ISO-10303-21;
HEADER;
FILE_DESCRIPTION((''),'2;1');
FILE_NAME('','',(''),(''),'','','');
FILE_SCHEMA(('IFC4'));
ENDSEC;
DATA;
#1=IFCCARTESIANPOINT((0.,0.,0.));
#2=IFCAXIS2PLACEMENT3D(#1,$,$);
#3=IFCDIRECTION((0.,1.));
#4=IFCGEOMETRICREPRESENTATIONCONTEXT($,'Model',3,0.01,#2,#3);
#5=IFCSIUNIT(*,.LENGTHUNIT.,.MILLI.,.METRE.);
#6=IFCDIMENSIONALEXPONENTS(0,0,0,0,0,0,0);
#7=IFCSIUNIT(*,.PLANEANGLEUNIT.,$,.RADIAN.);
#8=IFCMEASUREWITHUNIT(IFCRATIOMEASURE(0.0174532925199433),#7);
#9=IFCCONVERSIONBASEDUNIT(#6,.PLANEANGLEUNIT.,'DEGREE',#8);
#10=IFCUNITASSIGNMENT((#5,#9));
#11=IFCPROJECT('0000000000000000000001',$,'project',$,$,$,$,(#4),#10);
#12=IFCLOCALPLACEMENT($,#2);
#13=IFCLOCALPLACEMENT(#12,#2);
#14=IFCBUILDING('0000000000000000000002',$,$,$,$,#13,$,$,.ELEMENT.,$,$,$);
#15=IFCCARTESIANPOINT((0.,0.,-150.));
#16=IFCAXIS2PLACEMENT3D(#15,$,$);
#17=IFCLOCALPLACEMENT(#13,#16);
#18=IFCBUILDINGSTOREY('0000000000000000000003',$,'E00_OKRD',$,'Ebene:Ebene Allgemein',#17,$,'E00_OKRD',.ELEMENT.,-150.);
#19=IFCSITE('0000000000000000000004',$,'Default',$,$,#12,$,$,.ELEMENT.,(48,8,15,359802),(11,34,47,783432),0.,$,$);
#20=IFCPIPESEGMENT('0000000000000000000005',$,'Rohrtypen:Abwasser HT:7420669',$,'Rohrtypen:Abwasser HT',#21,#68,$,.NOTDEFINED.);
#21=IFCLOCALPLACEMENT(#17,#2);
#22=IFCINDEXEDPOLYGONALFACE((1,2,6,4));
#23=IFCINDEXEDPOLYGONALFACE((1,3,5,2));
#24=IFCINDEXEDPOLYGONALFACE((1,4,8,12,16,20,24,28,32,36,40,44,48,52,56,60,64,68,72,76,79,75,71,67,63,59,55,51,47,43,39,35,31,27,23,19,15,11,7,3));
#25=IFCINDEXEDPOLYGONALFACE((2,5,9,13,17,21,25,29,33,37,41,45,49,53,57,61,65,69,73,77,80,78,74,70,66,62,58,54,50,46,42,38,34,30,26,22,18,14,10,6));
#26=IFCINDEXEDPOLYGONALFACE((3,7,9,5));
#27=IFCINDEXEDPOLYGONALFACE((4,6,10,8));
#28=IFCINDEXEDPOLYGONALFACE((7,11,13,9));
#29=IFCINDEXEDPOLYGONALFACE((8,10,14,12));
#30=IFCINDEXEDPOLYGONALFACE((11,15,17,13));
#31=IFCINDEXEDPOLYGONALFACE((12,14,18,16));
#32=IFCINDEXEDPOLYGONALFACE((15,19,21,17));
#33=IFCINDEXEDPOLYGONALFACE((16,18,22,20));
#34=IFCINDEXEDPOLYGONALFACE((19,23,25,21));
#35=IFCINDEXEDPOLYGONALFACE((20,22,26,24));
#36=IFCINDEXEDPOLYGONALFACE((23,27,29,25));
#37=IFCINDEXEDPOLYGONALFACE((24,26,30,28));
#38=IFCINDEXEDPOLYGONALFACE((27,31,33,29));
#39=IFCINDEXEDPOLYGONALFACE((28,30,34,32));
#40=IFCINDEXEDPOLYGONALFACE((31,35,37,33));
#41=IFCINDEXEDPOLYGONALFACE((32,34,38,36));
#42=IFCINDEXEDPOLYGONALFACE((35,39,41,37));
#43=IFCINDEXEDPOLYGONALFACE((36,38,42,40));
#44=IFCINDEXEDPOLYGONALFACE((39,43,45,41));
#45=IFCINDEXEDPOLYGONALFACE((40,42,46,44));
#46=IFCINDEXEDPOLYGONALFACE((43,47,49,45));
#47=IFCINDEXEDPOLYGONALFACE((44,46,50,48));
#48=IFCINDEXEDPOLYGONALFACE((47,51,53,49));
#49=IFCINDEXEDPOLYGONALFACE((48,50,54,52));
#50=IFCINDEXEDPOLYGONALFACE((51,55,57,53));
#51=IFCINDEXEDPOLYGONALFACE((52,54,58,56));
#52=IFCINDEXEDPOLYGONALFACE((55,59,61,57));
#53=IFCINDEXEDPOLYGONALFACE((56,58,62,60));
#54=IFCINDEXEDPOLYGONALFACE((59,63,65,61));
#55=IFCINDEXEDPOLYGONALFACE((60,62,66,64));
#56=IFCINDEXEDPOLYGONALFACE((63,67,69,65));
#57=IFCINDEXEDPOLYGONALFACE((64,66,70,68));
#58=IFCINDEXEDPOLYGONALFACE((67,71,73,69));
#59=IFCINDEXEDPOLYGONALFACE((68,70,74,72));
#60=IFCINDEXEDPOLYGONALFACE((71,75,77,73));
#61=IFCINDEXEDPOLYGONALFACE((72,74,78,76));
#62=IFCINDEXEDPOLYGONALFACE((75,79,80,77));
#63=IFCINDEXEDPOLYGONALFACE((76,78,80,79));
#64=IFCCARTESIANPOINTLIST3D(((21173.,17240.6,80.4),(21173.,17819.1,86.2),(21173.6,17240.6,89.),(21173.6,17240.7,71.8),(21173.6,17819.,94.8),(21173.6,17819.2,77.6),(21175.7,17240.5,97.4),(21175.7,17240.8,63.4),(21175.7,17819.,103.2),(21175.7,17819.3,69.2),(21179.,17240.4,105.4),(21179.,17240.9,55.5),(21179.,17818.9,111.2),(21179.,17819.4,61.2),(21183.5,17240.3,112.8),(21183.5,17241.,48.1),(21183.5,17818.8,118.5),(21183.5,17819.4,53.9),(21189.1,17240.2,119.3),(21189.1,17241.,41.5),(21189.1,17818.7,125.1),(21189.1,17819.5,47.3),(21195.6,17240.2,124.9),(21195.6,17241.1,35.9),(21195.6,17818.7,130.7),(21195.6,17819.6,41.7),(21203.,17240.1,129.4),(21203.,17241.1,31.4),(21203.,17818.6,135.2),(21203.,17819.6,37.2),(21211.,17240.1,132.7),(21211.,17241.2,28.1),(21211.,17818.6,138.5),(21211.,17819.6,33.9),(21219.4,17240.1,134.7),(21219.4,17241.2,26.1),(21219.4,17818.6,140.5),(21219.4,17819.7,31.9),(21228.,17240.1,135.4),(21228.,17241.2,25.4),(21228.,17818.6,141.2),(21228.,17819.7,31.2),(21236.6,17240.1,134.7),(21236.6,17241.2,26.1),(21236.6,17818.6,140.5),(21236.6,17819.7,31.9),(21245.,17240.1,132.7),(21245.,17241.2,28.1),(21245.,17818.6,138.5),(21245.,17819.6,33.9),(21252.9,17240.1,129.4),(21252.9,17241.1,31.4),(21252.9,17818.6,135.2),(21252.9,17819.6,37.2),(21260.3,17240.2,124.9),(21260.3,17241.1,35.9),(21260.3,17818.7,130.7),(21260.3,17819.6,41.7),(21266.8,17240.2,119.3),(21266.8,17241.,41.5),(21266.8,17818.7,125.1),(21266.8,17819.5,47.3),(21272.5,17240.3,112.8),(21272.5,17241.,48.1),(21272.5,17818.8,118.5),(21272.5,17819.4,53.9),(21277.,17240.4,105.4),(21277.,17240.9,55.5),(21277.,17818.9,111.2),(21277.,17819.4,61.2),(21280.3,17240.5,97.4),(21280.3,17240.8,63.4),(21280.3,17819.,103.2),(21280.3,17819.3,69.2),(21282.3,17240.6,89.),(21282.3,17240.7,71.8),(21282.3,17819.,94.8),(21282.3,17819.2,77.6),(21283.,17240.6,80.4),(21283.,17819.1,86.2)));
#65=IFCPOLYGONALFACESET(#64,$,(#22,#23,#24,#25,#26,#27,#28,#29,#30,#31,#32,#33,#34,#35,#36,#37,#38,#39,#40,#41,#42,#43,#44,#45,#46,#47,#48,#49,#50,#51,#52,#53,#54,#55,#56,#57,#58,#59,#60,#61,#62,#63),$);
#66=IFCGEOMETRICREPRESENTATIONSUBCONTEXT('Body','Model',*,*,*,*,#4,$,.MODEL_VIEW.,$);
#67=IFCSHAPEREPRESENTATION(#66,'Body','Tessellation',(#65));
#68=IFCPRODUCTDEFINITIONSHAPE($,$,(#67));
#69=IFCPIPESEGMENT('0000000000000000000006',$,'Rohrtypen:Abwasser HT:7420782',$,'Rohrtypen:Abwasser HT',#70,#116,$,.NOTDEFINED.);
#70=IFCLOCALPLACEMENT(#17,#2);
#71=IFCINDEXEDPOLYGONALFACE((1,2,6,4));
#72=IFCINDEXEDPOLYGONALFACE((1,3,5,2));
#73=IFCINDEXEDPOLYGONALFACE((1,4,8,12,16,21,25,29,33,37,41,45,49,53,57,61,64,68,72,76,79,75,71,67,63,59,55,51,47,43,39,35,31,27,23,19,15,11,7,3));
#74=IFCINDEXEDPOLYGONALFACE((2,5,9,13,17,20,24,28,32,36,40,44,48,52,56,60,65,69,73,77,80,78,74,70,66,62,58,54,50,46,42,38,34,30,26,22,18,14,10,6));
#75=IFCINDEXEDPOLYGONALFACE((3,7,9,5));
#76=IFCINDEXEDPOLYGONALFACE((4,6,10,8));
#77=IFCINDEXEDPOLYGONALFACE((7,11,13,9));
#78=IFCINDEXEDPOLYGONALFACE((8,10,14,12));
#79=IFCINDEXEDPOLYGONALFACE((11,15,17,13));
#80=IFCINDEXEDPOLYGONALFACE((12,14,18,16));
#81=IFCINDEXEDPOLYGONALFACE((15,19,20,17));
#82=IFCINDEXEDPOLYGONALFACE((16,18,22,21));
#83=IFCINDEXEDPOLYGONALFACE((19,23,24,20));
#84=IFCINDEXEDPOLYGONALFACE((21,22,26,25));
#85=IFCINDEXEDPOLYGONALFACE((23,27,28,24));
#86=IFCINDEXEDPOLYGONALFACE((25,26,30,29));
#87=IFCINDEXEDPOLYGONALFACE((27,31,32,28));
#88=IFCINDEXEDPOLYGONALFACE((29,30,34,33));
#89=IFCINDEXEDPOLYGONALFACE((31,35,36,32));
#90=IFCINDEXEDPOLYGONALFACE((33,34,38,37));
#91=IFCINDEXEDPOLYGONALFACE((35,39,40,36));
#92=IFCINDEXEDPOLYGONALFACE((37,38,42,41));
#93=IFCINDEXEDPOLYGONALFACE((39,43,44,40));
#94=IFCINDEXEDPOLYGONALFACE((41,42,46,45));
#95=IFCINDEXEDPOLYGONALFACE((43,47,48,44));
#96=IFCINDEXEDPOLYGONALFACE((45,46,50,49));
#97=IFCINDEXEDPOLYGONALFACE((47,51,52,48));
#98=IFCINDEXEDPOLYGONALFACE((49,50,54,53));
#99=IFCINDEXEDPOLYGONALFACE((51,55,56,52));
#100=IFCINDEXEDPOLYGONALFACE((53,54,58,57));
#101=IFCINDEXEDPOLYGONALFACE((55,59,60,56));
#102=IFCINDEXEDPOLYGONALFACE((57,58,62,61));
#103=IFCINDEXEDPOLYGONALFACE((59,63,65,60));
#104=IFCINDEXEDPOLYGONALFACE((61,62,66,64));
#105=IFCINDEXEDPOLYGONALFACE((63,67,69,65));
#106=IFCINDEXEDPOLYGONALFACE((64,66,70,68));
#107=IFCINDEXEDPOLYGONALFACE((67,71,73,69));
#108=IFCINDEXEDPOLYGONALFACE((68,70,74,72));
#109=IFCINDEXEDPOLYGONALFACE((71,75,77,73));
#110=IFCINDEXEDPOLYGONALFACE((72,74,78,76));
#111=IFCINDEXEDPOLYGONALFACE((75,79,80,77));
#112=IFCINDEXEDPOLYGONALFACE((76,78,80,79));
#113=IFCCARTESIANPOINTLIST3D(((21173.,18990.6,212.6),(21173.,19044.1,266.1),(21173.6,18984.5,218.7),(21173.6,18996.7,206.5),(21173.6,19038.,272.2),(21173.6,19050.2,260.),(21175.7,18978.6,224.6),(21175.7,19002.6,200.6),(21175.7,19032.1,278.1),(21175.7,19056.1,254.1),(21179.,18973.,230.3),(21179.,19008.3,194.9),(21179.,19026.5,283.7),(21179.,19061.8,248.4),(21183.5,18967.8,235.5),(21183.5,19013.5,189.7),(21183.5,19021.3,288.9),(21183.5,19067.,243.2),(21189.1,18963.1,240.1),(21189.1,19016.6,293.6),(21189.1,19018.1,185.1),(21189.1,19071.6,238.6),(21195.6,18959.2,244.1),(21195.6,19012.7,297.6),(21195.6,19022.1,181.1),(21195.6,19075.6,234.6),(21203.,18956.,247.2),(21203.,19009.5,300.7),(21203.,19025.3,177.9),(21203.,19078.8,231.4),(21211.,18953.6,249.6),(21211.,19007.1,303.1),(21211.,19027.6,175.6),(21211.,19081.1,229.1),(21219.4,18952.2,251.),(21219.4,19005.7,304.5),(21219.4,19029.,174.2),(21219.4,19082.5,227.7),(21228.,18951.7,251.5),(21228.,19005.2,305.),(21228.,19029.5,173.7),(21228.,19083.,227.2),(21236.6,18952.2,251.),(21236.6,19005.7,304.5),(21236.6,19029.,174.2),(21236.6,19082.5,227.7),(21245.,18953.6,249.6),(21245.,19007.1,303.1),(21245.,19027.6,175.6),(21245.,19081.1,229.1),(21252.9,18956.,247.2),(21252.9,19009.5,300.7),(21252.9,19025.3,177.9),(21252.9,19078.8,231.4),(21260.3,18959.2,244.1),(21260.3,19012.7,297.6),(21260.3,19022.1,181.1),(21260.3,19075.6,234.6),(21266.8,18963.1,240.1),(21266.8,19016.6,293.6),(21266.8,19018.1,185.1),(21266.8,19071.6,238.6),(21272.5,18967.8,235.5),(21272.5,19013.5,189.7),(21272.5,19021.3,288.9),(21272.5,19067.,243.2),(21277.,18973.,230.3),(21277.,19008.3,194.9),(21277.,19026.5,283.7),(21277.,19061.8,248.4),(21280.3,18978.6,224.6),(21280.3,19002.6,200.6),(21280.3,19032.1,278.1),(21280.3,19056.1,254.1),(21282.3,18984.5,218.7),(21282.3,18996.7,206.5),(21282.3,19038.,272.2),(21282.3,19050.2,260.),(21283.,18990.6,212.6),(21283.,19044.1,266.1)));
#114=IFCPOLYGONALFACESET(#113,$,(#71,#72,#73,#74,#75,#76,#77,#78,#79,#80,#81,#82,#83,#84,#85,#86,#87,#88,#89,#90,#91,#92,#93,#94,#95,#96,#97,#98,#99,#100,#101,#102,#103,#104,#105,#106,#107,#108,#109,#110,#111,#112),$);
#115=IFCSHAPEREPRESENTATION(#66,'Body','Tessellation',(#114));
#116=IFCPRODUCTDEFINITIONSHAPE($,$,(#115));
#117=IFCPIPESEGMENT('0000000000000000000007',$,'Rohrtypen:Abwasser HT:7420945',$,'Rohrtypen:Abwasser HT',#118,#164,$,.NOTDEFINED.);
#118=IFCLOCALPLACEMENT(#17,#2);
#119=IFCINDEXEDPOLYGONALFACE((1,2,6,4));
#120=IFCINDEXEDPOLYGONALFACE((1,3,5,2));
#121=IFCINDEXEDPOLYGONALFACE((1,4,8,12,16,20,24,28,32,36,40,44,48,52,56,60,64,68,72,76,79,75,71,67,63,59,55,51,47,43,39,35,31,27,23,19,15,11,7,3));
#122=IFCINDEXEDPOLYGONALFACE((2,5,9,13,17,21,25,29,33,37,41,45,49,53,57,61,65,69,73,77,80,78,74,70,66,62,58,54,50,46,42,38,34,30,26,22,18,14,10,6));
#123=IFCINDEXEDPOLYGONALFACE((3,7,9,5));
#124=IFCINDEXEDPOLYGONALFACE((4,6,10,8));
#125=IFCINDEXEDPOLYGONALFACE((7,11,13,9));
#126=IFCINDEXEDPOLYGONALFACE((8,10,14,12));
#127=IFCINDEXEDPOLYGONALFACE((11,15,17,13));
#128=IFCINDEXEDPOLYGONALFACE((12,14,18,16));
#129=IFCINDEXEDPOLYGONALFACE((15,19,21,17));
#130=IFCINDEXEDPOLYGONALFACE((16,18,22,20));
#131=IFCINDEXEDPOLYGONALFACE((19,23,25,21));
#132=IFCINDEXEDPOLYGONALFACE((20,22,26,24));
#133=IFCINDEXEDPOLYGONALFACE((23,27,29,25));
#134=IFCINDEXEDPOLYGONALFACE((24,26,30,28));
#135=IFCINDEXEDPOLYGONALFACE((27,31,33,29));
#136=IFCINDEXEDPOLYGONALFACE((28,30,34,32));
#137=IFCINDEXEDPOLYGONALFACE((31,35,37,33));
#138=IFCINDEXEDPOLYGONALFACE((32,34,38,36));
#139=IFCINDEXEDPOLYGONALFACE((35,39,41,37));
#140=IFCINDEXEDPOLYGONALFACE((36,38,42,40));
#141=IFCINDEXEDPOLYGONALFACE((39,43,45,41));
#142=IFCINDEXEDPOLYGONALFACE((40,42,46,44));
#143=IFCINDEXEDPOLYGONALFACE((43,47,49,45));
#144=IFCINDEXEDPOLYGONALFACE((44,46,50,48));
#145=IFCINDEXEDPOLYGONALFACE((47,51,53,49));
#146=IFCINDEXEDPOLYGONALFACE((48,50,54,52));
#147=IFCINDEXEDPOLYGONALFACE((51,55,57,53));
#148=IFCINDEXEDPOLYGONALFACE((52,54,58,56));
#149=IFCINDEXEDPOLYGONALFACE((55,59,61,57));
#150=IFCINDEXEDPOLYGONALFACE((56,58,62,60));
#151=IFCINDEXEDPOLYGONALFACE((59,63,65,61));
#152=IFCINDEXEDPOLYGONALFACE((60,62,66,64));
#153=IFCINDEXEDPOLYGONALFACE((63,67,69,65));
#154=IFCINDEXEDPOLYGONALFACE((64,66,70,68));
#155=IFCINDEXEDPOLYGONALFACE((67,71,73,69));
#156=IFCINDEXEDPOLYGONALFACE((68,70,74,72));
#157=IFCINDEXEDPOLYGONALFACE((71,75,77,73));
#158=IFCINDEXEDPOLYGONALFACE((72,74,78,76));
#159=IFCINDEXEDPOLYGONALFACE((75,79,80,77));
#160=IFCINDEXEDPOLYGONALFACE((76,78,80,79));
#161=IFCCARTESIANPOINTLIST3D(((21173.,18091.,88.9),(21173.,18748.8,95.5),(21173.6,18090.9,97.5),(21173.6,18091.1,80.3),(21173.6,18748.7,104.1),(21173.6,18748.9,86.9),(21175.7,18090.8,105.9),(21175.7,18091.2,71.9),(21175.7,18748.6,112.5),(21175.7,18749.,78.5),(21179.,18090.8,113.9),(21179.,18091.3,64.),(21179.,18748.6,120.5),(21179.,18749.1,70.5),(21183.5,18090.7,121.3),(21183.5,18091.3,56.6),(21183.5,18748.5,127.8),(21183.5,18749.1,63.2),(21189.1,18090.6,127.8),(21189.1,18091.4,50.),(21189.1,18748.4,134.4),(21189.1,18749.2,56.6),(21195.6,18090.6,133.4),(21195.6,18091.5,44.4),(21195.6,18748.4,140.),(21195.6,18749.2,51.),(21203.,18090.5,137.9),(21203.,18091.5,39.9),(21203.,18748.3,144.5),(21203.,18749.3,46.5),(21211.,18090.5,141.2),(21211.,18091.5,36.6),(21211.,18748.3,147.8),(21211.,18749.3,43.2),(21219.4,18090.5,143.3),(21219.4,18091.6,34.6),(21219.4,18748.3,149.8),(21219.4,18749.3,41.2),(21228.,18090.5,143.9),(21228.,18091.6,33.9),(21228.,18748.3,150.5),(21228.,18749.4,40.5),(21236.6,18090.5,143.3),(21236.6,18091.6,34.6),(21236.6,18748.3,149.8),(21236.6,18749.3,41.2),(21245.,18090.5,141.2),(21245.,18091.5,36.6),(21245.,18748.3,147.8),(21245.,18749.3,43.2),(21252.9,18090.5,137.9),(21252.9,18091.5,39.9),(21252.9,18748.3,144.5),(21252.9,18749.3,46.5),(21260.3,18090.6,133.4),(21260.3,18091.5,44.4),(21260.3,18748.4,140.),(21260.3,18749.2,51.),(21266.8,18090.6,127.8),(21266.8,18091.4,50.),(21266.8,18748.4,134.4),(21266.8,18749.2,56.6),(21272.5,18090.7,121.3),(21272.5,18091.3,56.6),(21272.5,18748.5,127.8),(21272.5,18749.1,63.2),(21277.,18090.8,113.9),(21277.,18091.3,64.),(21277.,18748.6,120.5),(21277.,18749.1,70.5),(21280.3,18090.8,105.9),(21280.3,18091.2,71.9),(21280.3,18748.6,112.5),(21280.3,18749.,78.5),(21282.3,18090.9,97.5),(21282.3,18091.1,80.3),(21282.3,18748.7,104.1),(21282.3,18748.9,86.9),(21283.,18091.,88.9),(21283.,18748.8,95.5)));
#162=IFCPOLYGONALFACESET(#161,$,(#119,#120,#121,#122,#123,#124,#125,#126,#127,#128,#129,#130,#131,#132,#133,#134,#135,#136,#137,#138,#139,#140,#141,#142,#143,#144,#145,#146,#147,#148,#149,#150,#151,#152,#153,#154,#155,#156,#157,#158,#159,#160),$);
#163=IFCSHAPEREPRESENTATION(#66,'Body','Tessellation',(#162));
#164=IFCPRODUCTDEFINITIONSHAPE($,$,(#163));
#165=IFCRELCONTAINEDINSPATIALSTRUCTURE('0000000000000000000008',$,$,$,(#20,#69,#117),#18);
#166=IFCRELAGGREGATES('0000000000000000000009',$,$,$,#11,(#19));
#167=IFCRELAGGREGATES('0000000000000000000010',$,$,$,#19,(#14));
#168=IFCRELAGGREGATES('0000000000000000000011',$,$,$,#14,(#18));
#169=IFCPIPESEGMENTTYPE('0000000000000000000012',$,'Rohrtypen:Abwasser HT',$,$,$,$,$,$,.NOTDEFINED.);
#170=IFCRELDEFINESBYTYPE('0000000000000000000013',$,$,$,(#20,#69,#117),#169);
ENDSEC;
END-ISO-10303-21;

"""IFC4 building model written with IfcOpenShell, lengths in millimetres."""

from ifc_helpers import new_model, entity, si_unit, converted_unit, direction, frame, origin, place, context, subcontext, project, spatial, indexed_curve, outline, extrude, type_object, element, save


model = new_model("IFC4")

# Units and contexts
model_context = context("Model", 3, precision=0.01, world=origin(), true_north=direction((0.0, 1.0)))
body_context = subcontext(model_context, "Body", "Model", "MODEL_VIEW")
ifc_project = project(units=[si_unit("LENGTHUNIT", "METRE", prefix="MILLI"), converted_unit("PLANEANGLEUNIT", "DEGREE", entity("IfcRatioMeasure", 0.0174532925199433), si_unit("PLANEANGLEUNIT", "RADIAN"), dimensions=[0, 0, 0, 0, 0, 0, 0])], contexts=[model_context])

# Site, building, storey
site_placement = place(None, origin())
site = spatial("IfcSite", under=ifc_project, at=site_placement, Name="Default", CompositionType="ELEMENT", RefLatitude=(48, 8, 15, 359802), RefLongitude=(11, 34, 47, 783432), RefElevation=0.0)
building_placement = place(site_placement, origin())
building = spatial("IfcBuilding", under=site, at=building_placement, CompositionType="ELEMENT")
storey_placement = place(building_placement, frame((0.0, 0.0, -150.0)))
storey = spatial("IfcBuildingStorey", under=building, at=storey_placement, Name="E00_OKRD", ObjectType="Ebene:Ebene Allgemein", LongName="E00_OKRD", CompositionType="ELEMENT", Elevation=-150.0)

# Pipe segments
pipe_segment_type_1 = type_object("IfcPipeSegmentType", Name="Rohrtypen:Abwasser HT", PredefinedType="NOTDEFINED")
pipe_segment_1_placement = place(storey_placement, origin())
element("IfcPipeSegment", 1, at=pipe_segment_1_placement, inside=storey, type_object=pipe_segment_type_1, Name="Rohrtypen:Abwasser HT:7420669", ObjectType="Rohrtypen:Abwasser HT", PredefinedType="NOTDEFINED", context=body_context, shape_type="SweptSolid", body=[
    extrude(outline(indexed_curve([(55.0, 0.0), (54.3, 8.6), (52.3, 17.0), (49.0, 25.0), (44.5, 32.3), (38.9, 38.9), (32.3, 44.5), (25.0, 49.0), (17.0, 52.3), (8.6, 54.3), (0.0, 55.0), (-8.6, 54.3), (-17.0, 52.3), (-25.0, 49.0), (-32.3, 44.5), (-38.9, 38.9), (-44.5, 32.3), (-49.0, 25.0), (-52.3, 17.0), (-54.3, 8.6), (-55.0, 0.0), (-54.3, -8.6), (-52.3, -17.0), (-49.0, -25.0), (-44.5, -32.3), (-38.9, -38.9), (-32.3, -44.5), (-25.0, -49.0), (-17.0, -52.3), (-8.6, -54.3), (0.0, -55.0), (8.6, -54.3), (17.0, -52.3), (25.0, -49.0), (32.3, -44.5), (38.9, -38.9), (44.5, -32.3), (49.0, -25.0), (52.3, -17.0), (54.3, -8.6), (55.0, 0.0)], self_intersect=False)), frame((21228.0, 17240.6, 80.4), z_axis=(0.0, 0.99995, 0.01), x_axis=(-1.0, 0.0, 0.0)), (0.0, 0.0, 1.0), 578.5),
])
pipe_segment_2_placement = place(storey_placement, origin())
element("IfcPipeSegment", 2, at=pipe_segment_2_placement, inside=storey, type_object=pipe_segment_type_1, Name="Rohrtypen:Abwasser HT:7420782", ObjectType="Rohrtypen:Abwasser HT", PredefinedType="NOTDEFINED", context=body_context, shape_type="SweptSolid", body=[
    extrude(outline(indexed_curve([(55.0, 0.0), (54.3, 8.6), (52.3, 17.0), (49.0, 25.0), (44.5, 32.3), (38.9, 38.9), (32.3, 44.5), (25.0, 49.0), (17.0, 52.3), (8.6, 54.3), (0.0, 55.0), (-8.6, 54.3), (-17.0, 52.3), (-25.0, 49.0), (-32.3, 44.5), (-38.9, 38.9), (-44.5, 32.3), (-49.0, 25.0), (-52.3, 17.0), (-54.3, 8.6), (-55.0, 0.0), (-54.3, -8.6), (-52.3, -17.0), (-49.0, -25.0), (-44.5, -32.3), (-38.9, -38.9), (-32.3, -44.5), (-25.0, -49.0), (-17.0, -52.3), (-8.6, -54.3), (0.0, -55.0), (8.6, -54.3), (17.0, -52.3), (25.0, -49.0), (32.3, -44.5), (38.9, -38.9), (44.5, -32.3), (49.0, -25.0), (52.3, -17.0), (54.3, -8.6), (55.0, 0.0)], self_intersect=False)), frame((21228.0, 18990.6, 212.6), z_axis=(0.0, 0.707107, 0.707107), x_axis=(-1.0, 0.0, 0.0)), (0.0, 0.0, 1.0), 75.7),
])
pipe_segment_3_placement = place(storey_placement, origin())
element("IfcPipeSegment", 3, at=pipe_segment_3_placement, inside=storey, type_object=pipe_segment_type_1, Name="Rohrtypen:Abwasser HT:7420945", ObjectType="Rohrtypen:Abwasser HT", PredefinedType="NOTDEFINED", context=body_context, shape_type="SweptSolid", body=[
    extrude(outline(indexed_curve([(55.0, 0.0), (54.3, 8.6), (52.3, 17.0), (49.0, 25.0), (44.5, 32.3), (38.9, 38.9), (32.3, 44.5), (25.0, 49.0), (17.0, 52.3), (8.6, 54.3), (0.0, 55.0), (-8.6, 54.3), (-17.0, 52.3), (-25.0, 49.0), (-32.3, 44.5), (-38.9, 38.9), (-44.5, 32.3), (-49.0, 25.0), (-52.3, 17.0), (-54.3, 8.6), (-55.0, 0.0), (-54.3, -8.6), (-52.3, -17.0), (-49.0, -25.0), (-44.5, -32.3), (-38.9, -38.9), (-32.3, -44.5), (-25.0, -49.0), (-17.0, -52.3), (-8.6, -54.3), (0.0, -55.0), (8.6, -54.3), (17.0, -52.3), (25.0, -49.0), (32.3, -44.5), (38.9, -38.9), (44.5, -32.3), (49.0, -25.0), (52.3, -17.0), (54.3, -8.6), (55.0, 0.0)], self_intersect=False)), frame((21228.0, 18091.0, 88.9), z_axis=(0.000001, 0.99995, 0.009999), x_axis=(1.0, -0.000001, 0.0)), (0.0, 0.0, 1.0), 657.8),
])

save(model, "model.ifc")
